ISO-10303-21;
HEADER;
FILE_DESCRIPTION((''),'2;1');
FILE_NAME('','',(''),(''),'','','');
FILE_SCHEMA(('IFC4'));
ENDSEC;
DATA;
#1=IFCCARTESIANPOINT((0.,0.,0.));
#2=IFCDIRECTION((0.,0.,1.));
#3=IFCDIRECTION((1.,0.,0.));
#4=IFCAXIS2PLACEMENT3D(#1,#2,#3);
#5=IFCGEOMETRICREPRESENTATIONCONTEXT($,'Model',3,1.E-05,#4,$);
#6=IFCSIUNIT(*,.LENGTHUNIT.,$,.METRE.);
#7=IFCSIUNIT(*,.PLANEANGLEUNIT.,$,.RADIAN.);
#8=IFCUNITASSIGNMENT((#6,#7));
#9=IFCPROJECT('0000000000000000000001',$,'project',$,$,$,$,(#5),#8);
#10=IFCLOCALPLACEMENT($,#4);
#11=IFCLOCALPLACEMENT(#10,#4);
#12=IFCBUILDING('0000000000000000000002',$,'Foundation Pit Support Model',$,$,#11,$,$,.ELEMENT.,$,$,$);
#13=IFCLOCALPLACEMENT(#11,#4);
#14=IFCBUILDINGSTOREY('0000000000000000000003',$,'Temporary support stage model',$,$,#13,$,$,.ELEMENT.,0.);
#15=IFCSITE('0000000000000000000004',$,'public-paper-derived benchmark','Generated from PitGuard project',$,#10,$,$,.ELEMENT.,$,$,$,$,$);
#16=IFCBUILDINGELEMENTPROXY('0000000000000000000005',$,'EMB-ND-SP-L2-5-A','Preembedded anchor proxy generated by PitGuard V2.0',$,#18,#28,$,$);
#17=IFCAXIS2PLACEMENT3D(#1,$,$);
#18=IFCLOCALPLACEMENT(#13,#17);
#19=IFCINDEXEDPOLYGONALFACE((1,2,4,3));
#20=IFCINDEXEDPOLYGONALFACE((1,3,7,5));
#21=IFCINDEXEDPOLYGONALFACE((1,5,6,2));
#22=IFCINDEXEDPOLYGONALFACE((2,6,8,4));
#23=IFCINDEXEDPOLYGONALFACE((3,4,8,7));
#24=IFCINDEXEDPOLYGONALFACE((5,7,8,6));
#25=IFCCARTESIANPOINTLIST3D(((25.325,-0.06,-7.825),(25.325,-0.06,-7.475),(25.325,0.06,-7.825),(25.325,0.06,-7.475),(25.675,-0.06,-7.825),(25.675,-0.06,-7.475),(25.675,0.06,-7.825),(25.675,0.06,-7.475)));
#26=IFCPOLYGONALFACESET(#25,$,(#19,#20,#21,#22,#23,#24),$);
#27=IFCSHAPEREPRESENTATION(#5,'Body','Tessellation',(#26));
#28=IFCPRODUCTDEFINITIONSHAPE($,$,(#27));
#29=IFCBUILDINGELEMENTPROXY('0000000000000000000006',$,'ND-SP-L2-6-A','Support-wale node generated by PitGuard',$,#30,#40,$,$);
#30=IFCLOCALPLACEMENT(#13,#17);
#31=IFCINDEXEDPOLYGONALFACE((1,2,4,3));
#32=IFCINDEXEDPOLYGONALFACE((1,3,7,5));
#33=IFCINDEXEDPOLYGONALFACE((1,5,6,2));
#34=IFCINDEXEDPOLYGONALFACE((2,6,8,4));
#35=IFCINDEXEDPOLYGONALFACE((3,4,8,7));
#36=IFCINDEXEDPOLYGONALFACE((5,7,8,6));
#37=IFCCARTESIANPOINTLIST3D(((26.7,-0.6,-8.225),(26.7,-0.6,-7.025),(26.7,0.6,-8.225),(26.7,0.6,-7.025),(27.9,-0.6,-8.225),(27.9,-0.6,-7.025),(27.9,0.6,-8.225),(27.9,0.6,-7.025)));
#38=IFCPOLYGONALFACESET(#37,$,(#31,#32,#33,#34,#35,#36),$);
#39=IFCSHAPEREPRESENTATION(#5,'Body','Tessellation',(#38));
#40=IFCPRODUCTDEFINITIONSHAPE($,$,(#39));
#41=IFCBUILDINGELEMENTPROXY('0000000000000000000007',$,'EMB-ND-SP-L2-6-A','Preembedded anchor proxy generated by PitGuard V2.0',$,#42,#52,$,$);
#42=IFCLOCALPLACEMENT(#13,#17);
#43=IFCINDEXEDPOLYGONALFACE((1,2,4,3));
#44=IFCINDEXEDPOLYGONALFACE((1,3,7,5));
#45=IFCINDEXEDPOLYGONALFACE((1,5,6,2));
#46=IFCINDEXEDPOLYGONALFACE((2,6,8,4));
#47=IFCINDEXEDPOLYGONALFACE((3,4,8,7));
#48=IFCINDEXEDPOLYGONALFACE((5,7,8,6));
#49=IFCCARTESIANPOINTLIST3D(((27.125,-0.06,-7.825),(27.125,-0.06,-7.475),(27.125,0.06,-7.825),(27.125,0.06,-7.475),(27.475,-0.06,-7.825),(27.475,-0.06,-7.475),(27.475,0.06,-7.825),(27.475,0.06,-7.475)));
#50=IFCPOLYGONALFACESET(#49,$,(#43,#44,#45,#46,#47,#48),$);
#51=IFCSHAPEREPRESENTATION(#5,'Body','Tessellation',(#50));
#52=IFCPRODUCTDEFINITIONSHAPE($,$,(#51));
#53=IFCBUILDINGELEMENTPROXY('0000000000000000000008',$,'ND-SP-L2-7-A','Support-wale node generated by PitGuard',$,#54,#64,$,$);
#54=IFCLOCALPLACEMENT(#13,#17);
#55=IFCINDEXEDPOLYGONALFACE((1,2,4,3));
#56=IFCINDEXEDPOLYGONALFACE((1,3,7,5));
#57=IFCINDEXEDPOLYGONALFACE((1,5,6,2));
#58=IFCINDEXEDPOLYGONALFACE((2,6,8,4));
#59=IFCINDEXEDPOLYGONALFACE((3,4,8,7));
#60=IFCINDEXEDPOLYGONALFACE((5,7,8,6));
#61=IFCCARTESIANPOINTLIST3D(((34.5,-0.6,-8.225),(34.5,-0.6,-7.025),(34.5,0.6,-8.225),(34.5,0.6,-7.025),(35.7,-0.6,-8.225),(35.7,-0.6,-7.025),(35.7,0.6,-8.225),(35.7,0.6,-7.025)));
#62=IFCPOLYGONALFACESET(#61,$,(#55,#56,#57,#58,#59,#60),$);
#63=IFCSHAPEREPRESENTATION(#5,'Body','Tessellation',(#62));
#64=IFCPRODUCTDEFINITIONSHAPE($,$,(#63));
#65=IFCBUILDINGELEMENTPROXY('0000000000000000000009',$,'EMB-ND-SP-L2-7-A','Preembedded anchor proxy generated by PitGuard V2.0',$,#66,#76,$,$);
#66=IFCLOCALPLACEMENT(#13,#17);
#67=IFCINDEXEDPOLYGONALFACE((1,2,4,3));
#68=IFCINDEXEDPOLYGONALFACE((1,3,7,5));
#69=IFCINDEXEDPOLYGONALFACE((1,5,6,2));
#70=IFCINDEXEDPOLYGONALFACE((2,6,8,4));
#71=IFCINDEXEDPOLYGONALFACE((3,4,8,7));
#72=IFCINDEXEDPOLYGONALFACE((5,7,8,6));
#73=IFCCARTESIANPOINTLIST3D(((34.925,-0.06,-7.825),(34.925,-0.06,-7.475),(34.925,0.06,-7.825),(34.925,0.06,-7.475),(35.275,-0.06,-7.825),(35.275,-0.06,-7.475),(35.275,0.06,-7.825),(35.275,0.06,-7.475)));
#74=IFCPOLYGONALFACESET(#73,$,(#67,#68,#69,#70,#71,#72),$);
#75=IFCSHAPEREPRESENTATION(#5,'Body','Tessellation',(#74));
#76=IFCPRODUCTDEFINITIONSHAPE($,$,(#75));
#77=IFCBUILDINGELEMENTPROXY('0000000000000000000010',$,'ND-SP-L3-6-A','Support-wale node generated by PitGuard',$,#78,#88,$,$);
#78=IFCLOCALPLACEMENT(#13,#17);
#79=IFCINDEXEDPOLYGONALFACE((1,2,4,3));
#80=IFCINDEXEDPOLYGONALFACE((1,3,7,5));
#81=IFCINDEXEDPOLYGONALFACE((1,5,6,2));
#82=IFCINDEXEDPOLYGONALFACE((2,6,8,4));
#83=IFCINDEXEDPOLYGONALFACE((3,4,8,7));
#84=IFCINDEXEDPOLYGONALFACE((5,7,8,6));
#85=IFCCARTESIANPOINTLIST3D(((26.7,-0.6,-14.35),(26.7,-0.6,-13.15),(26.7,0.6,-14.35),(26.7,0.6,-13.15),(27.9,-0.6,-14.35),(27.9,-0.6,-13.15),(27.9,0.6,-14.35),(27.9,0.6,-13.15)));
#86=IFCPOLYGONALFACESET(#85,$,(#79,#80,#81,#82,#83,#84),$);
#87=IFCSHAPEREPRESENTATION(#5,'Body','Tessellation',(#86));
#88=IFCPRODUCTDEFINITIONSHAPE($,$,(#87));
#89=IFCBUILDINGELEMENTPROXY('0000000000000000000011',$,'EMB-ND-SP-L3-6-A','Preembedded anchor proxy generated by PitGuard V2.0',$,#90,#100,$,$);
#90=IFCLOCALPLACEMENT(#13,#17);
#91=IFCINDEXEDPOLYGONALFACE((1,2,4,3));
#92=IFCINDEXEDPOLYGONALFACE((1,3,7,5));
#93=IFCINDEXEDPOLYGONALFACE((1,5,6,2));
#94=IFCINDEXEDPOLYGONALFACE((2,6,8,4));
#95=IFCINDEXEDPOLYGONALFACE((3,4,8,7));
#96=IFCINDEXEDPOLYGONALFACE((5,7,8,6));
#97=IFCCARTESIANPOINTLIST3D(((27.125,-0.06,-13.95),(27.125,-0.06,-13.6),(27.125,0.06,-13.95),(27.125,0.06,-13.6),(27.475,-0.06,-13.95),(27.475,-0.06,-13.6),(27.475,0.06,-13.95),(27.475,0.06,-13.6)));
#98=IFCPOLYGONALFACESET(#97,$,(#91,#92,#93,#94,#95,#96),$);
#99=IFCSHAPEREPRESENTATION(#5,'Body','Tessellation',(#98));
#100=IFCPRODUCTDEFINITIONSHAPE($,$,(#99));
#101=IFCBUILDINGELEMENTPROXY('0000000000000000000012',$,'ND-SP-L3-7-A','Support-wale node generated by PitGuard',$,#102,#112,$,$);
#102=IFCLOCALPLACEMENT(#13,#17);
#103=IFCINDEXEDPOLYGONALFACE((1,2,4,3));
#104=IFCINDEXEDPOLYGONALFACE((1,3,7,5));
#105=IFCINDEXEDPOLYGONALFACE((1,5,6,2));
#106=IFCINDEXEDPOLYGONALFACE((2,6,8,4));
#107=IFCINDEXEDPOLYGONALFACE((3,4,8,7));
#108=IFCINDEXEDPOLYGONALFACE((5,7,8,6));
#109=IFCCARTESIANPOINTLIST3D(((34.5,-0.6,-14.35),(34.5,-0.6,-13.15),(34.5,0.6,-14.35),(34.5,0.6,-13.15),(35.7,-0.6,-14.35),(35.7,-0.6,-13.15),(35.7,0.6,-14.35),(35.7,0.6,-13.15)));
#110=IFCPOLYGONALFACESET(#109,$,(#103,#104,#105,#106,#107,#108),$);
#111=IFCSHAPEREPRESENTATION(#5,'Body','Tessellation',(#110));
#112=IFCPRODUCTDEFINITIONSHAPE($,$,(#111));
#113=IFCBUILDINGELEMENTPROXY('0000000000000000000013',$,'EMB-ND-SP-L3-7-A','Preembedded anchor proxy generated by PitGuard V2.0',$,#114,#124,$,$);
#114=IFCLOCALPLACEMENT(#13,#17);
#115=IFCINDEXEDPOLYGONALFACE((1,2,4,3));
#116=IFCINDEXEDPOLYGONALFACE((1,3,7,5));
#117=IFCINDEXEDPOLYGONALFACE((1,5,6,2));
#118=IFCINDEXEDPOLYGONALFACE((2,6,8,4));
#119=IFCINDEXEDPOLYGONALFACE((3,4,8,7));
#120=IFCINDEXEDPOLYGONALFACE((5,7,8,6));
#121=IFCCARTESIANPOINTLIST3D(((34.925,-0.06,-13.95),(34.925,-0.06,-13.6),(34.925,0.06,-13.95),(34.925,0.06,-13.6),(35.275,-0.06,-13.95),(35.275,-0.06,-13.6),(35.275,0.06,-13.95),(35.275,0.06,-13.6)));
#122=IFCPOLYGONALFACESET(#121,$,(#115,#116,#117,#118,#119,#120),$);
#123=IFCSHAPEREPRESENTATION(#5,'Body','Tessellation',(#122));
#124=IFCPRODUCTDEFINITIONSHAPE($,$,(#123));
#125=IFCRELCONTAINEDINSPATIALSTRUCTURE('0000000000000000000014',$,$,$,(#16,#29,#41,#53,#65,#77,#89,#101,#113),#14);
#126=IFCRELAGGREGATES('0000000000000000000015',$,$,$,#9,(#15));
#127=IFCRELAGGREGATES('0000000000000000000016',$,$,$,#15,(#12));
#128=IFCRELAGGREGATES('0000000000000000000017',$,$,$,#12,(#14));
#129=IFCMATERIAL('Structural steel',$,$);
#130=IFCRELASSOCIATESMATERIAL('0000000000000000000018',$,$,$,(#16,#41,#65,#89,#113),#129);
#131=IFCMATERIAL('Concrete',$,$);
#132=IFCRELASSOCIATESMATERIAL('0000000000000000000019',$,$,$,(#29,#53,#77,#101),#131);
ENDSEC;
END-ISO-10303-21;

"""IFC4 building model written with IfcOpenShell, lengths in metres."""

from ifc_helpers import new_model, si_unit, frame, origin_with_axes, origin_2d, place, context, project, spatial, rectangle, extrude, material, element, save


model = new_model("IFC4")

# Units and contexts
model_context = context("Model", 3, precision=1e-05, world=origin_with_axes())
ifc_project = project(units=[si_unit("LENGTHUNIT", "METRE"), si_unit("PLANEANGLEUNIT", "RADIAN")], contexts=[model_context])

# Site, building, storey
site_placement = place(None, origin_with_axes())
site = spatial("IfcSite", under=ifc_project, at=site_placement, Name="public-paper-derived benchmark", Description="Generated from PitGuard project", CompositionType="ELEMENT")
building_placement = place(site_placement, origin_with_axes())
building = spatial("IfcBuilding", under=site, at=building_placement, Name="Foundation Pit Support Model", CompositionType="ELEMENT")
storey_placement = place(building_placement, origin_with_axes())
storey = spatial("IfcBuildingStorey", under=building, at=storey_placement, Name="Temporary support stage model", CompositionType="ELEMENT", Elevation=0.0)

# Shared definitions
ifc_material_1 = material(Name="Concrete")

# Shared definitions
ifc_material_2 = material(Name="Structural steel")

# Building element proxies
proxy_1_placement = place(storey_placement, frame((25.5, 0.0, -7.825), z_axis=(0.0, 0.0, 1.0), x_axis=(1.0, 0.0, 0.0)))
element("IfcBuildingElementProxy", 1, at=proxy_1_placement, inside=storey, material=ifc_material_2, Name="EMB-ND-SP-L2-5-A", Description="Preembedded anchor proxy generated by PitGuard V2.0", context=model_context, shape_type="SweptSolid", body=[
    extrude(rectangle(XDim=0.35, YDim=0.12, at=origin_2d()), origin_with_axes(), (0.0, 0.0, 1.0), 0.35),
])
proxy_2_placement = place(storey_placement, frame((27.3, 0.0, -8.225), z_axis=(0.0, 0.0, 1.0), x_axis=(1.0, 0.0, 0.0)))
element("IfcBuildingElementProxy", 2, at=proxy_2_placement, inside=storey, material=ifc_material_1, Name="ND-SP-L2-6-A", Description="Support-wale node generated by PitGuard", context=model_context, shape_type="SweptSolid", body=[
    extrude(rectangle(XDim=1.2, YDim=1.2, at=origin_2d()), origin_with_axes(), (0.0, 0.0, 1.0), 1.2),
])
proxy_3_placement = place(storey_placement, frame((27.3, 0.0, -7.825), z_axis=(0.0, 0.0, 1.0), x_axis=(1.0, 0.0, 0.0)))
element("IfcBuildingElementProxy", 3, at=proxy_3_placement, inside=storey, material=ifc_material_2, Name="EMB-ND-SP-L2-6-A", Description="Preembedded anchor proxy generated by PitGuard V2.0", context=model_context, shape_type="SweptSolid", body=[
    extrude(rectangle(XDim=0.35, YDim=0.12, at=origin_2d()), origin_with_axes(), (0.0, 0.0, 1.0), 0.35),
])
proxy_4_placement = place(storey_placement, frame((35.1, 0.0, -8.225), z_axis=(0.0, 0.0, 1.0), x_axis=(1.0, 0.0, 0.0)))
element("IfcBuildingElementProxy", 4, at=proxy_4_placement, inside=storey, material=ifc_material_1, Name="ND-SP-L2-7-A", Description="Support-wale node generated by PitGuard", context=model_context, shape_type="SweptSolid", body=[
    extrude(rectangle(XDim=1.2, YDim=1.2, at=origin_2d()), origin_with_axes(), (0.0, 0.0, 1.0), 1.2),
])
proxy_5_placement = place(storey_placement, frame((35.1, 0.0, -7.825), z_axis=(0.0, 0.0, 1.0), x_axis=(1.0, 0.0, 0.0)))
element("IfcBuildingElementProxy", 5, at=proxy_5_placement, inside=storey, material=ifc_material_2, Name="EMB-ND-SP-L2-7-A", Description="Preembedded anchor proxy generated by PitGuard V2.0", context=model_context, shape_type="SweptSolid", body=[
    extrude(rectangle(XDim=0.35, YDim=0.12, at=origin_2d()), origin_with_axes(), (0.0, 0.0, 1.0), 0.35),
])
proxy_6_placement = place(storey_placement, frame((27.3, 0.0, -14.35), z_axis=(0.0, 0.0, 1.0), x_axis=(1.0, 0.0, 0.0)))
element("IfcBuildingElementProxy", 6, at=proxy_6_placement, inside=storey, material=ifc_material_1, Name="ND-SP-L3-6-A", Description="Support-wale node generated by PitGuard", context=model_context, shape_type="SweptSolid", body=[
    extrude(rectangle(XDim=1.2, YDim=1.2, at=origin_2d()), origin_with_axes(), (0.0, 0.0, 1.0), 1.2),
])
proxy_7_placement = place(storey_placement, frame((27.3, 0.0, -13.95), z_axis=(0.0, 0.0, 1.0), x_axis=(1.0, 0.0, 0.0)))
element("IfcBuildingElementProxy", 7, at=proxy_7_placement, inside=storey, material=ifc_material_2, Name="EMB-ND-SP-L3-6-A", Description="Preembedded anchor proxy generated by PitGuard V2.0", context=model_context, shape_type="SweptSolid", body=[
    extrude(rectangle(XDim=0.35, YDim=0.12, at=origin_2d()), origin_with_axes(), (0.0, 0.0, 1.0), 0.35),
])
proxy_8_placement = place(storey_placement, frame((35.1, 0.0, -14.35), z_axis=(0.0, 0.0, 1.0), x_axis=(1.0, 0.0, 0.0)))
element("IfcBuildingElementProxy", 8, at=proxy_8_placement, inside=storey, material=ifc_material_1, Name="ND-SP-L3-7-A", Description="Support-wale node generated by PitGuard", context=model_context, shape_type="SweptSolid", body=[
    extrude(rectangle(XDim=1.2, YDim=1.2, at=origin_2d()), origin_with_axes(), (0.0, 0.0, 1.0), 1.2),
])
proxy_9_placement = place(storey_placement, frame((35.1, 0.0, -13.95), z_axis=(0.0, 0.0, 1.0), x_axis=(1.0, 0.0, 0.0)))
element("IfcBuildingElementProxy", 9, at=proxy_9_placement, inside=storey, material=ifc_material_2, Name="EMB-ND-SP-L3-7-A", Description="Preembedded anchor proxy generated by PitGuard V2.0", context=model_context, shape_type="SweptSolid", body=[
    extrude(rectangle(XDim=0.35, YDim=0.12, at=origin_2d()), origin_with_axes(), (0.0, 0.0, 1.0), 0.35),
])

save(model, "model.ifc")
